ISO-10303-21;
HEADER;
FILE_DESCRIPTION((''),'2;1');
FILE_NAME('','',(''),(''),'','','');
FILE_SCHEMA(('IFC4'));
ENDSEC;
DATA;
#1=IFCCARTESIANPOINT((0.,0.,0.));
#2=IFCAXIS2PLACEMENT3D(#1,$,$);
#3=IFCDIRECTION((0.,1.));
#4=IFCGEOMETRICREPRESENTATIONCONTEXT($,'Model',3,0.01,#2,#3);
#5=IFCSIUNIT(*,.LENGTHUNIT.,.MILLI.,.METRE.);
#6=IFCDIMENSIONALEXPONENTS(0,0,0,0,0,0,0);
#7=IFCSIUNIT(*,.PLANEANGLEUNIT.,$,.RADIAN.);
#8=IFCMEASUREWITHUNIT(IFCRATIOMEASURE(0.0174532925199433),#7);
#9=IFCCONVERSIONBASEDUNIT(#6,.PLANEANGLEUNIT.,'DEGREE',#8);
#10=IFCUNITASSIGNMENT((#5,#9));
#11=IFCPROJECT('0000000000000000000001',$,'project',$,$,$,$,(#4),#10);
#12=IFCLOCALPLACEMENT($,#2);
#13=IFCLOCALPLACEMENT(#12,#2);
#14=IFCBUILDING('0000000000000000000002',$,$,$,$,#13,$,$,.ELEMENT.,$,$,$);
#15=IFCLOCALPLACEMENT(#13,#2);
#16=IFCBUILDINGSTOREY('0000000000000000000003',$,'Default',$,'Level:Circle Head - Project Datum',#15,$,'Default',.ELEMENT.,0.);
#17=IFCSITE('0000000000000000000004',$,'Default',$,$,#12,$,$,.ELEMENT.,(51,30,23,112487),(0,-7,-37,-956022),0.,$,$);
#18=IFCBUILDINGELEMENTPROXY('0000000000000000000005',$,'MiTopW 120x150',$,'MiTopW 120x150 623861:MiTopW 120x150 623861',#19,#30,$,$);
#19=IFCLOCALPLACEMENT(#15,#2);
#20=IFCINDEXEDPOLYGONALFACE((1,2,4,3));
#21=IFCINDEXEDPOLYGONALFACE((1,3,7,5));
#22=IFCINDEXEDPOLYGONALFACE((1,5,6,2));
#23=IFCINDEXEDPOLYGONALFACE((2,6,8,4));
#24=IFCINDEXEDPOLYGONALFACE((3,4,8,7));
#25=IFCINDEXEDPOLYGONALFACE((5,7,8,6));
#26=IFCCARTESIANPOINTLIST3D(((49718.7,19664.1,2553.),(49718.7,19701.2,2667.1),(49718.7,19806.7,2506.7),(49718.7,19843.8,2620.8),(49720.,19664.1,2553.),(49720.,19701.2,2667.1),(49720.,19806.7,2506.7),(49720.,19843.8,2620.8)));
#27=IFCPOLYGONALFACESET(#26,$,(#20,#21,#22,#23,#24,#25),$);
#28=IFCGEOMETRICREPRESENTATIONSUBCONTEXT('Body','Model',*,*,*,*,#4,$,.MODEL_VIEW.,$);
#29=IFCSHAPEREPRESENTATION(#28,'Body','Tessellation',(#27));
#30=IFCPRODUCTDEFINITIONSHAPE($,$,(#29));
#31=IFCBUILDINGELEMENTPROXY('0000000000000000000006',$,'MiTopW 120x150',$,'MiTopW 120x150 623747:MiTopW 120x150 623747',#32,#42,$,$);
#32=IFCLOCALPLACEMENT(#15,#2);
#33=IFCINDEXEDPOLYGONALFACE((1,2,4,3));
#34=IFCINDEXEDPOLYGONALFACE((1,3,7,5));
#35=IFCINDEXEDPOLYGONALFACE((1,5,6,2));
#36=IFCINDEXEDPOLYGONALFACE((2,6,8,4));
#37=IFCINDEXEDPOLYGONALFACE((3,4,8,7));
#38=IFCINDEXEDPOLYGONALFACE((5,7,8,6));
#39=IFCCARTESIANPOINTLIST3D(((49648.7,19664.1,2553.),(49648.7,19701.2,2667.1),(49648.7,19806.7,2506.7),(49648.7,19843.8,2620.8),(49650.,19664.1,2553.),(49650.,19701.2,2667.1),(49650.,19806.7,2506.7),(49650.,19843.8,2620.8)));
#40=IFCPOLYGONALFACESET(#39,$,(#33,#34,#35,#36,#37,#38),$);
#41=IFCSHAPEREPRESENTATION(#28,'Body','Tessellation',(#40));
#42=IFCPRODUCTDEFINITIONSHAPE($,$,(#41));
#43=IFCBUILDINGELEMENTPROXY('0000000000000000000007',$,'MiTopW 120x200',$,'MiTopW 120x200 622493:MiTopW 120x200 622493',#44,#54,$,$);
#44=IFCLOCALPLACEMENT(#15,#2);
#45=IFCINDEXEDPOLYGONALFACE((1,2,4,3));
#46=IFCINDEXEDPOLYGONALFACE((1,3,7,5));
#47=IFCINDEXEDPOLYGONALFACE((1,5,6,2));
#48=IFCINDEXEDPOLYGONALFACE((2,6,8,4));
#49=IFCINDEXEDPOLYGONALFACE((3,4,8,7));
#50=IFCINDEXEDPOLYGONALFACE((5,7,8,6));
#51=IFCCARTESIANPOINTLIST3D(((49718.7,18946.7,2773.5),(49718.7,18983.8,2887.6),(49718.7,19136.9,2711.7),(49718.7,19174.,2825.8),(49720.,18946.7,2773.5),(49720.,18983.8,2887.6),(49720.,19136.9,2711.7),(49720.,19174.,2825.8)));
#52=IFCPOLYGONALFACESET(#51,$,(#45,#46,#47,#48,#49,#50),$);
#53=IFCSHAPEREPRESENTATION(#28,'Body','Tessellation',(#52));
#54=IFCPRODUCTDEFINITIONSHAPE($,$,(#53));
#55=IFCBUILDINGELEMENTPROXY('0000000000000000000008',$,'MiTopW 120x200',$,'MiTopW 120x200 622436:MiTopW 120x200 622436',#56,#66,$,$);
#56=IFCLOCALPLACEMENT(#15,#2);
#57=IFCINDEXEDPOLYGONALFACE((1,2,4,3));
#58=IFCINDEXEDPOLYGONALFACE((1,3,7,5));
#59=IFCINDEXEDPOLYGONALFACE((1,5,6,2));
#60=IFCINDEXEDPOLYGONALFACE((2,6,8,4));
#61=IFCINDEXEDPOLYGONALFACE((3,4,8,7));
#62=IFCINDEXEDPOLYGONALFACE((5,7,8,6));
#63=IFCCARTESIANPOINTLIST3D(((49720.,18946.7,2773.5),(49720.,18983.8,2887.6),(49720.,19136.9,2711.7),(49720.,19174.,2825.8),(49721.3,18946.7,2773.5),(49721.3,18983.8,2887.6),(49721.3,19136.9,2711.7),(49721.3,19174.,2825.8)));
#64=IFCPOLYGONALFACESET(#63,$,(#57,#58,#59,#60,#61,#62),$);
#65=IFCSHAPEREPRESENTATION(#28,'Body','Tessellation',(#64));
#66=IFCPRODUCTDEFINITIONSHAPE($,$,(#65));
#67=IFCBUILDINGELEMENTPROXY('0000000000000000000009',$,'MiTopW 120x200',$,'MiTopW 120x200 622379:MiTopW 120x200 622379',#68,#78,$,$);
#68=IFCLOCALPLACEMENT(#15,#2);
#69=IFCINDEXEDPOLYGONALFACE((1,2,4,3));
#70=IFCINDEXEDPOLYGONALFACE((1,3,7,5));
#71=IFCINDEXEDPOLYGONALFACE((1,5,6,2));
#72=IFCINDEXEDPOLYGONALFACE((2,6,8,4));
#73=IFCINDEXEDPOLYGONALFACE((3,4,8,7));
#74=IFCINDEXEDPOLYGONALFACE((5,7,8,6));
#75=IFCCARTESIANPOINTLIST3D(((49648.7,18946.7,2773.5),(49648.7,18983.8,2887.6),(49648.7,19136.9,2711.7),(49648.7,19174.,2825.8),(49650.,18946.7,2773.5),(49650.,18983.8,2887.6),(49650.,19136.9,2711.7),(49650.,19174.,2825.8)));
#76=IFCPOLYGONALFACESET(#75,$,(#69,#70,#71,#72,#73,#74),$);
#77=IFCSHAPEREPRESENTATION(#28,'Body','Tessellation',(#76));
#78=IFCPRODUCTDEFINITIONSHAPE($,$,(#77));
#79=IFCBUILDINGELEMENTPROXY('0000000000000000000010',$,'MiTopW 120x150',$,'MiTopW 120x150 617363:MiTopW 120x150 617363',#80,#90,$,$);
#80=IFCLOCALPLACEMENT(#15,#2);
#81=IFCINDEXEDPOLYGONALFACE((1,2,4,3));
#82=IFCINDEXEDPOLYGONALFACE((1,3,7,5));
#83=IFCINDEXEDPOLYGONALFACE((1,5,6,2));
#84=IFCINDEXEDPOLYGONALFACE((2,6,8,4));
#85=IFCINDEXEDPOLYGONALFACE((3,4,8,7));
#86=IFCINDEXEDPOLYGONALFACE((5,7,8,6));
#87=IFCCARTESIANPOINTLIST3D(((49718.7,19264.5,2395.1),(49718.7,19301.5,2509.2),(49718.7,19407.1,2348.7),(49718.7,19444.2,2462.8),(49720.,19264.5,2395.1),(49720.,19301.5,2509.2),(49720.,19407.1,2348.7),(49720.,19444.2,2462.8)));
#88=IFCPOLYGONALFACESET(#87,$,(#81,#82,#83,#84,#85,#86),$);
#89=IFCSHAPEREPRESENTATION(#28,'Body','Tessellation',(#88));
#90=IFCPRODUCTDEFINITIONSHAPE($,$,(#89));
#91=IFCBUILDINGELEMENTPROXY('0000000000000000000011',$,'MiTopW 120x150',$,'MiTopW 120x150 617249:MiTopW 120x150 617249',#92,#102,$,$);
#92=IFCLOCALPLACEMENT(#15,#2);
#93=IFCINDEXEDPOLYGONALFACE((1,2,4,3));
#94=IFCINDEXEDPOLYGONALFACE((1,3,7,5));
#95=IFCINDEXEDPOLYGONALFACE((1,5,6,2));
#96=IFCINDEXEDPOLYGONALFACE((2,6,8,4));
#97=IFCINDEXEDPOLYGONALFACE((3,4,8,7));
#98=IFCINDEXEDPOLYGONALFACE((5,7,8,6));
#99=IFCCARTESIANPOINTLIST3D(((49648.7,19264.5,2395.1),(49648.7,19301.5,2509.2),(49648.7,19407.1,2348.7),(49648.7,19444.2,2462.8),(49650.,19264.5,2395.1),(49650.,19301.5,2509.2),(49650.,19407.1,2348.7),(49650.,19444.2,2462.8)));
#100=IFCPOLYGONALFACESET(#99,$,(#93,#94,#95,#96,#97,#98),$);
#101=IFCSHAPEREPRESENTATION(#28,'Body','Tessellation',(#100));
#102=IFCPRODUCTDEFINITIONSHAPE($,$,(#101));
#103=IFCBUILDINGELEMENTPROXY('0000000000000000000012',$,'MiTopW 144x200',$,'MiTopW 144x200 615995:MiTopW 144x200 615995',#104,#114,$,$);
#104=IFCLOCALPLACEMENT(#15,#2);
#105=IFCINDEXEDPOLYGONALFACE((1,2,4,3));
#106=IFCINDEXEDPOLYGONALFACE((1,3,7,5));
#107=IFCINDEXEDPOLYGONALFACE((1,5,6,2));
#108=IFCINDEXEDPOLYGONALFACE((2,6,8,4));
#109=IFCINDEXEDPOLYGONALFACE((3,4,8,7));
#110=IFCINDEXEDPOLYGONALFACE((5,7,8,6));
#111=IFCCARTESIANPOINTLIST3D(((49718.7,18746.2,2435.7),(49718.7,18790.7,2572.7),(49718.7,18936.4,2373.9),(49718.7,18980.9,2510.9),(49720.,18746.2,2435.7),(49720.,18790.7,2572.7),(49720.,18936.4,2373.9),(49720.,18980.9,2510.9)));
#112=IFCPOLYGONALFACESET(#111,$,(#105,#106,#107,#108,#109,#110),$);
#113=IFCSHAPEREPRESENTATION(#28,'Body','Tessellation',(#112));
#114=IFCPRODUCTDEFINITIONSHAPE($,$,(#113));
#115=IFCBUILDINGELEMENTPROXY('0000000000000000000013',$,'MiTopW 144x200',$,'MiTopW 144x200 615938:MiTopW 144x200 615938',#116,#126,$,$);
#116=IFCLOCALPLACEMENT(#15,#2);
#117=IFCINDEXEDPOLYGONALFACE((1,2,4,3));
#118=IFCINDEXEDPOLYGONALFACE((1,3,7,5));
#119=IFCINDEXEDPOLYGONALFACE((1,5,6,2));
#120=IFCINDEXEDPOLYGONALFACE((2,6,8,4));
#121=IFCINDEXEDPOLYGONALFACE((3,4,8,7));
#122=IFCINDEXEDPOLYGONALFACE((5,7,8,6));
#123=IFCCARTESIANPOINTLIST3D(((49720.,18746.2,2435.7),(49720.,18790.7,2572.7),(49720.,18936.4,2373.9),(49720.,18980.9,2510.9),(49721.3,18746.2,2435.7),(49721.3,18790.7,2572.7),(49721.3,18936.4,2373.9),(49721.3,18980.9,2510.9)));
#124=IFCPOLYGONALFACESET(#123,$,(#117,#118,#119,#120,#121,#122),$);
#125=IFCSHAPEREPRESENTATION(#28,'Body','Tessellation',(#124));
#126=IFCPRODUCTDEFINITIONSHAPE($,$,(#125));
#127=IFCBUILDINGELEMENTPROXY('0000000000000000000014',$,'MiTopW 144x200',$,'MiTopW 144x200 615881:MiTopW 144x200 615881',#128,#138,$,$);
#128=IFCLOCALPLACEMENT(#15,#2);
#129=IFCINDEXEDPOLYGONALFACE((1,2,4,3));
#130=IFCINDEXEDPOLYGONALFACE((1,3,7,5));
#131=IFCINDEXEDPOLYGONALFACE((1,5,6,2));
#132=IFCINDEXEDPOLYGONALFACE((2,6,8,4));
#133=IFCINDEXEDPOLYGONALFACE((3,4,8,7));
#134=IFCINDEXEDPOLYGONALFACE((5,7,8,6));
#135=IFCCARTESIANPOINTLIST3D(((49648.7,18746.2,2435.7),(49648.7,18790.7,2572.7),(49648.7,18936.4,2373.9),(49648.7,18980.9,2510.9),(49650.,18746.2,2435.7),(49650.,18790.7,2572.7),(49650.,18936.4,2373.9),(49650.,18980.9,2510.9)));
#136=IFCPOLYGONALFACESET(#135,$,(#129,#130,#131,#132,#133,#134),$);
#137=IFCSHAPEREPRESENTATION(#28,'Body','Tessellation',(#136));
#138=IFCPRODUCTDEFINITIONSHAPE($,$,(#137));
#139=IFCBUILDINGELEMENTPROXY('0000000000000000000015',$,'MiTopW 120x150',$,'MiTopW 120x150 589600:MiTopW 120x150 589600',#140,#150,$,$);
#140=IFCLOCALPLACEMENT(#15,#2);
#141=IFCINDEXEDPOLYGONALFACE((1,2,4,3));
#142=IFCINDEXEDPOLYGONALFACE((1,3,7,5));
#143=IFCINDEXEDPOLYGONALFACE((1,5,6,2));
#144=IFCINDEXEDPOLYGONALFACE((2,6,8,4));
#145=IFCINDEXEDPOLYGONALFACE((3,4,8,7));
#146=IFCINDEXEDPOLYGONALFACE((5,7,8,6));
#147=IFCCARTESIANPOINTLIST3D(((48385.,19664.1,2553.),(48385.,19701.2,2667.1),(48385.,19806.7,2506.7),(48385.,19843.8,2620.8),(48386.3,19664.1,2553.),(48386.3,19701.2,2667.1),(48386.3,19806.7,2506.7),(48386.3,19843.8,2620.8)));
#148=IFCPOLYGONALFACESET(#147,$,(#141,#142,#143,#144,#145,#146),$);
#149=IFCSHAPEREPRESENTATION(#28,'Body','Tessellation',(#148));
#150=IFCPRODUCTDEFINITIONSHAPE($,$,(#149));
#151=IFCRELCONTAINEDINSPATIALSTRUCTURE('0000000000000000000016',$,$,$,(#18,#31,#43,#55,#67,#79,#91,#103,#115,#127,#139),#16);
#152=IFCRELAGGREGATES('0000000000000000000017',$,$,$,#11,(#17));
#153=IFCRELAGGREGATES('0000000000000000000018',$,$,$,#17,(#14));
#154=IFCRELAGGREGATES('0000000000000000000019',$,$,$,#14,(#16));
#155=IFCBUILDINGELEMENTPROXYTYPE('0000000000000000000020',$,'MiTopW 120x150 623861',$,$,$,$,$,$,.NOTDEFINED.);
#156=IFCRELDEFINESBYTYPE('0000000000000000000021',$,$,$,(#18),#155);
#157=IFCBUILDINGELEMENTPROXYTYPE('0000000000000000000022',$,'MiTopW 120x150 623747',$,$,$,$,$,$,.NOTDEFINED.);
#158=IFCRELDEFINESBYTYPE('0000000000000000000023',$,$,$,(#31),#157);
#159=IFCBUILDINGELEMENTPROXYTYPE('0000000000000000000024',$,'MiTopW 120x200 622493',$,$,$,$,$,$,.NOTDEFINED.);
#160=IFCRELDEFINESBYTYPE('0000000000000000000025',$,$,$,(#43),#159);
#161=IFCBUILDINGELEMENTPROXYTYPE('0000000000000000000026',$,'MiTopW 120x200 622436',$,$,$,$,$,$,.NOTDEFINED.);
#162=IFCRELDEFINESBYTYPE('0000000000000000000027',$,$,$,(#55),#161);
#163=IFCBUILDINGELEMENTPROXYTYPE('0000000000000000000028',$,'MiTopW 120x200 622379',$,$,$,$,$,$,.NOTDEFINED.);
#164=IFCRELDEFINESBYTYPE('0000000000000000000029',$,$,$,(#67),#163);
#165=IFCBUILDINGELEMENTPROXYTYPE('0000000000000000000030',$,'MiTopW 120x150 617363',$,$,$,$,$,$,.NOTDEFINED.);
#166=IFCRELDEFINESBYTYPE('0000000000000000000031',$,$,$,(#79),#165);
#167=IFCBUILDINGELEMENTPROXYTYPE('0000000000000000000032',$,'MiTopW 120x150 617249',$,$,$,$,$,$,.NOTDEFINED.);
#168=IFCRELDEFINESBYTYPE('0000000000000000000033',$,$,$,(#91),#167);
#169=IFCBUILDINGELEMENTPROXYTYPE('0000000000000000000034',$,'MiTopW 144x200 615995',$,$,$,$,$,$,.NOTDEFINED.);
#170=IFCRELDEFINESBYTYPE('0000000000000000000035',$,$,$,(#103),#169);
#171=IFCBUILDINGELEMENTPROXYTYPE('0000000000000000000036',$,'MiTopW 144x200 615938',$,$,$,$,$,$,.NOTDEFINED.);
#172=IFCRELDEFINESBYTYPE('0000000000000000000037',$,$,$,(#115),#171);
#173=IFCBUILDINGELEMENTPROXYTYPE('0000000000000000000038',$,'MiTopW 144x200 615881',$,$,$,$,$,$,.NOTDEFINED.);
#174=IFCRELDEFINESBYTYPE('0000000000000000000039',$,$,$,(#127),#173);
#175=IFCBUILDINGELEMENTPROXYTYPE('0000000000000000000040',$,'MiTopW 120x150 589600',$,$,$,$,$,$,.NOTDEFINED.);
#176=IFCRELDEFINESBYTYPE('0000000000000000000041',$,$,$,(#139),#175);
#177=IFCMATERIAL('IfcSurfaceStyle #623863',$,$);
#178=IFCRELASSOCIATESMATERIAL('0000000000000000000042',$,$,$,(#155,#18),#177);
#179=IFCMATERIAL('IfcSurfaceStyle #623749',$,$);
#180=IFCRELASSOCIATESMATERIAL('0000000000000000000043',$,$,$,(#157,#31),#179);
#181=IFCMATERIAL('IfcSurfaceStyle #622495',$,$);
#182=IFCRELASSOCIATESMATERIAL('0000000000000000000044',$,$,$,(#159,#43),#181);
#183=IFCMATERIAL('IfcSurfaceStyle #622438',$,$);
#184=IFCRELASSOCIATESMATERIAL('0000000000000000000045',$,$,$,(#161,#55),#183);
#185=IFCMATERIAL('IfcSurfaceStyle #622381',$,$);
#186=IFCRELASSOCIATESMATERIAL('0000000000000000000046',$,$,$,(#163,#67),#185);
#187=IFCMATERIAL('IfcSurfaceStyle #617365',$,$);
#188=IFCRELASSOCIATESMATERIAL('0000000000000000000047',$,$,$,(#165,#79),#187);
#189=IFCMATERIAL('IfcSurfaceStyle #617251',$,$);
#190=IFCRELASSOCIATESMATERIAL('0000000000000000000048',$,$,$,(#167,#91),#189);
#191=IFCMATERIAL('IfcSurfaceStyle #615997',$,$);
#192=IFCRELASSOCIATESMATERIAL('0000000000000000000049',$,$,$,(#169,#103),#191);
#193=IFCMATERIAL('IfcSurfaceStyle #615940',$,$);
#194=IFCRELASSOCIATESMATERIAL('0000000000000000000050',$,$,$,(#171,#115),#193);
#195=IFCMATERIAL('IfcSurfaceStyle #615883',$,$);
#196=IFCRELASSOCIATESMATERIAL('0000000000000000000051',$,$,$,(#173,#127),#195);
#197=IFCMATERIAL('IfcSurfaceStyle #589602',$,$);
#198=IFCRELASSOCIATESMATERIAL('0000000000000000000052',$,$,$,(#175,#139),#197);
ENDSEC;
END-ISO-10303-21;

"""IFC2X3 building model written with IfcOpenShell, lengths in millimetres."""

from ifc_helpers import new_model, entity, si_unit, converted_unit, direction, frame, origin, place, context, subcontext, project, spatial, polyline, outline, extrude, source, transform, mapped, material, type_object, type_shapes, element, save


model = new_model("IFC2X3")

# Units and contexts
model_context = context("Model", 3, precision=0.01, world=origin(), true_north=direction((0.0, 1.0)))
body_context = subcontext(model_context, "Body", "Model", "MODEL_VIEW")
ifc_project = project(units=[si_unit("LENGTHUNIT", "METRE", prefix="MILLI"), converted_unit("PLANEANGLEUNIT", "DEGREE", entity("IfcRatioMeasure", 0.0174532925199433), si_unit("PLANEANGLEUNIT", "RADIAN"), dimensions=[0, 0, 0, 0, 0, 0, 0])], contexts=[model_context])

# Site, building, storey
site_placement = place(None, origin())
site = spatial("IfcSite", under=ifc_project, at=site_placement, Name="Default", CompositionType="ELEMENT", RefLatitude=(51, 30, 23, 112487), RefLongitude=(0, -7, -37, -956022), RefElevation=0.0)
building_placement = place(site_placement, origin())
building = spatial("IfcBuilding", under=site, at=building_placement, CompositionType="ELEMENT")
storey_placement = place(building_placement, origin())
storey = spatial("IfcBuildingStorey", under=building, at=storey_placement, Name="Default", ObjectType="Level:Circle Head - Project Datum", LongName="Default", CompositionType="ELEMENT", Elevation=0.0)

# Building element proxies
ifc_material_1 = material(Name="IfcSurfaceStyle #623863")
building_element_proxy_type_1 = type_object("IfcBuildingElementProxyType", Name="MiTopW 120x150 623861", PredefinedType="NOTDEFINED", material=ifc_material_1)
shared_shape_1 = source(origin(), body_context, "Body", "SweptSolid", [
    extrude(outline(polyline([(-75.0, -60.0), (75.0, -60.0), (75.0, 60.0), (-75.0, 60.0), (-75.0, -60.0)])), frame((75.0, 60.0, 0.0), z_axis=(0.0, 0.0, 1.0), x_axis=(-1.0, 0.0, 0.0)), (0.0, 0.0, 1.0), 1.3),
])
type_shapes(building_element_proxy_type_1, [shared_shape_1])
proxy_1_placement = place(building_placement, frame((49720.0, 19806.7, 2506.7), z_axis=(-1.0, 0.0, 0.0), x_axis=(0.0, -0.951057, 0.309017)))
element("IfcBuildingElementProxy", 1, at=proxy_1_placement, inside=storey, type_object=building_element_proxy_type_1, material=ifc_material_1, Name="MiTopW 120x150", ObjectType="MiTopW 120x150 623861:MiTopW 120x150 623861", context=body_context, shape_type="MappedRepresentation", body=[
    mapped(shared_shape_1, transform((0.0, 0.0, 0.0), scale=1.0)),
])
ifc_material_2 = material(Name="IfcSurfaceStyle #623749")
building_element_proxy_type_2 = type_object("IfcBuildingElementProxyType", Name="MiTopW 120x150 623747", PredefinedType="NOTDEFINED", material=ifc_material_2)
shared_shape_2 = source(origin(), body_context, "Body", "SweptSolid", [
    extrude(outline(polyline([(-75.0, -60.0), (75.0, -60.0), (75.0, 60.0), (-75.0, 60.0), (-75.0, -60.0)])), frame((75.0, 60.0, 0.0), z_axis=(0.0, 0.0, 1.0), x_axis=(-1.0, 0.0, 0.0)), (0.0, 0.0, 1.0), 1.3),
])
type_shapes(building_element_proxy_type_2, [shared_shape_2])
proxy_2_placement = place(building_placement, frame((49650.0, 19806.7, 2506.7), z_axis=(-1.0, 0.0, 0.0), x_axis=(0.0, -0.951057, 0.309017)))
element("IfcBuildingElementProxy", 2, at=proxy_2_placement, inside=storey, type_object=building_element_proxy_type_2, material=ifc_material_2, Name="MiTopW 120x150", ObjectType="MiTopW 120x150 623747:MiTopW 120x150 623747", context=body_context, shape_type="MappedRepresentation", body=[
    mapped(shared_shape_2, transform((0.0, 0.0, 0.0), scale=1.0)),
])
ifc_material_3 = material(Name="IfcSurfaceStyle #622495")
building_element_proxy_type_3 = type_object("IfcBuildingElementProxyType", Name="MiTopW 120x200 622493", PredefinedType="NOTDEFINED", material=ifc_material_3)
shared_shape_3 = source(origin(), body_context, "Body", "SweptSolid", [
    extrude(outline(polyline([(-100.0, -60.0), (100.0, -60.0), (100.0, 60.0), (-100.0, 60.0), (-100.0, -60.0)])), frame((100.0, 60.0, 0.0), z_axis=(0.0, 0.0, 1.0), x_axis=(-1.0, 0.0, 0.0)), (0.0, 0.0, 1.0), 1.3),
])
type_shapes(building_element_proxy_type_3, [shared_shape_3])
proxy_3_placement = place(building_placement, frame((49720.0, 19136.9, 2711.7), z_axis=(-1.0, 0.0, 0.0), x_axis=(0.0, -0.951057, 0.309017)))
element("IfcBuildingElementProxy", 3, at=proxy_3_placement, inside=storey, type_object=building_element_proxy_type_3, material=ifc_material_3, Name="MiTopW 120x200", ObjectType="MiTopW 120x200 622493:MiTopW 120x200 622493", context=body_context, shape_type="MappedRepresentation", body=[
    mapped(shared_shape_3, transform((0.0, 0.0, 0.0), scale=1.0)),
])
ifc_material_4 = material(Name="IfcSurfaceStyle #622438")
building_element_proxy_type_4 = type_object("IfcBuildingElementProxyType", Name="MiTopW 120x200 622436", PredefinedType="NOTDEFINED", material=ifc_material_4)
shared_shape_4 = source(origin(), body_context, "Body", "SweptSolid", [
    extrude(outline(polyline([(-100.0, -60.0), (100.0, -60.0), (100.0, 60.0), (-100.0, 60.0), (-100.0, -60.0)])), frame((100.0, 60.0, 0.0), z_axis=(0.0, 0.0, 1.0), x_axis=(-1.0, 0.0, 0.0)), (0.0, 0.0, 1.0), 1.3),
])
type_shapes(building_element_proxy_type_4, [shared_shape_4])
proxy_4_placement = place(building_placement, frame((49721.3, 19136.9, 2711.7), z_axis=(-1.0, 0.0, 0.0), x_axis=(0.0, -0.951057, 0.309017)))
element("IfcBuildingElementProxy", 4, at=proxy_4_placement, inside=storey, type_object=building_element_proxy_type_4, material=ifc_material_4, Name="MiTopW 120x200", ObjectType="MiTopW 120x200 622436:MiTopW 120x200 622436", context=body_context, shape_type="MappedRepresentation", body=[
    mapped(shared_shape_4, transform((0.0, 0.0, 0.0), scale=1.0)),
])
ifc_material_5 = material(Name="IfcSurfaceStyle #622381")
building_element_proxy_type_5 = type_object("IfcBuildingElementProxyType", Name="MiTopW 120x200 622379", PredefinedType="NOTDEFINED", material=ifc_material_5)
shared_shape_5 = source(origin(), body_context, "Body", "SweptSolid", [
    extrude(outline(polyline([(-100.0, -60.0), (100.0, -60.0), (100.0, 60.0), (-100.0, 60.0), (-100.0, -60.0)])), frame((100.0, 60.0, 0.0), z_axis=(0.0, 0.0, 1.0), x_axis=(-1.0, 0.0, 0.0)), (0.0, 0.0, 1.0), 1.3),
])
type_shapes(building_element_proxy_type_5, [shared_shape_5])
proxy_5_placement = place(building_placement, frame((49650.0, 19136.9, 2711.7), z_axis=(-1.0, 0.0, 0.0), x_axis=(0.0, -0.951057, 0.309017)))
element("IfcBuildingElementProxy", 5, at=proxy_5_placement, inside=storey, type_object=building_element_proxy_type_5, material=ifc_material_5, Name="MiTopW 120x200", ObjectType="MiTopW 120x200 622379:MiTopW 120x200 622379", context=body_context, shape_type="MappedRepresentation", body=[
    mapped(shared_shape_5, transform((0.0, 0.0, 0.0), scale=1.0)),
])
ifc_material_6 = material(Name="IfcSurfaceStyle #617365")
building_element_proxy_type_6 = type_object("IfcBuildingElementProxyType", Name="MiTopW 120x150 617363", PredefinedType="NOTDEFINED", material=ifc_material_6)
shared_shape_6 = source(origin(), body_context, "Body", "SweptSolid", [
    extrude(outline(polyline([(-75.0, -60.0), (75.0, -60.0), (75.0, 60.0), (-75.0, 60.0), (-75.0, -60.0)])), frame((75.0, 60.0, 0.0), z_axis=(0.0, 0.0, 1.0), x_axis=(-1.0, 0.0, 0.0)), (0.0, 0.0, 1.0), 1.3),
])
type_shapes(building_element_proxy_type_6, [shared_shape_6])
proxy_6_placement = place(building_placement, frame((49720.0, 19407.1, 2348.7), z_axis=(-1.0, 0.0, 0.0), x_axis=(0.0, -0.951057, 0.309017)))
element("IfcBuildingElementProxy", 6, at=proxy_6_placement, inside=storey, type_object=building_element_proxy_type_6, material=ifc_material_6, Name="MiTopW 120x150", ObjectType="MiTopW 120x150 617363:MiTopW 120x150 617363", context=body_context, shape_type="MappedRepresentation", body=[
    mapped(shared_shape_6, transform((0.0, 0.0, 0.0), scale=1.0)),
])
ifc_material_7 = material(Name="IfcSurfaceStyle #617251")
building_element_proxy_type_7 = type_object("IfcBuildingElementProxyType", Name="MiTopW 120x150 617249", PredefinedType="NOTDEFINED", material=ifc_material_7)
shared_shape_7 = source(origin(), body_context, "Body", "SweptSolid", [
    extrude(outline(polyline([(-75.0, -60.0), (75.0, -60.0), (75.0, 60.0), (-75.0, 60.0), (-75.0, -60.0)])), frame((75.0, 60.0, 0.0), z_axis=(0.0, 0.0, 1.0), x_axis=(-1.0, 0.0, 0.0)), (0.0, 0.0, 1.0), 1.3),
])
type_shapes(building_element_proxy_type_7, [shared_shape_7])
proxy_7_placement = place(building_placement, frame((49650.0, 19407.1, 2348.7), z_axis=(-1.0, 0.0, 0.0), x_axis=(0.0, -0.951057, 0.309017)))
element("IfcBuildingElementProxy", 7, at=proxy_7_placement, inside=storey, type_object=building_element_proxy_type_7, material=ifc_material_7, Name="MiTopW 120x150", ObjectType="MiTopW 120x150 617249:MiTopW 120x150 617249", context=body_context, shape_type="MappedRepresentation", body=[
    mapped(shared_shape_7, transform((0.0, 0.0, 0.0), scale=1.0)),
])
ifc_material_8 = material(Name="IfcSurfaceStyle #615997")
building_element_proxy_type_8 = type_object("IfcBuildingElementProxyType", Name="MiTopW 144x200 615995", PredefinedType="NOTDEFINED", material=ifc_material_8)
shared_shape_8 = source(origin(), body_context, "Body", "SweptSolid", [
    extrude(outline(polyline([(-100.0, -72.0), (100.0, -72.0), (100.0, 72.0), (-100.0, 72.0), (-100.0, -72.0)])), frame((100.0, 72.0, 0.0), z_axis=(0.0, 0.0, 1.0), x_axis=(-1.0, 0.0, 0.0)), (0.0, 0.0, 1.0), 1.3),
])
type_shapes(building_element_proxy_type_8, [shared_shape_8])
proxy_8_placement = place(building_placement, frame((49720.0, 18936.4, 2373.9), z_axis=(-1.0, 0.0, 0.0), x_axis=(0.0, -0.951057, 0.309017)))
element("IfcBuildingElementProxy", 8, at=proxy_8_placement, inside=storey, type_object=building_element_proxy_type_8, material=ifc_material_8, Name="MiTopW 144x200", ObjectType="MiTopW 144x200 615995:MiTopW 144x200 615995", context=body_context, shape_type="MappedRepresentation", body=[
    mapped(shared_shape_8, transform((0.0, 0.0, 0.0), scale=1.0)),
])
ifc_material_9 = material(Name="IfcSurfaceStyle #615940")
building_element_proxy_type_9 = type_object("IfcBuildingElementProxyType", Name="MiTopW 144x200 615938", PredefinedType="NOTDEFINED", material=ifc_material_9)
shared_shape_9 = source(origin(), body_context, "Body", "SweptSolid", [
    extrude(outline(polyline([(-100.0, -72.0), (100.0, -72.0), (100.0, 72.0), (-100.0, 72.0), (-100.0, -72.0)])), frame((100.0, 72.0, 0.0), z_axis=(0.0, 0.0, 1.0), x_axis=(-1.0, 0.0, 0.0)), (0.0, 0.0, 1.0), 1.3),
])
type_shapes(building_element_proxy_type_9, [shared_shape_9])
proxy_9_placement = place(building_placement, frame((49721.3, 18936.4, 2373.9), z_axis=(-1.0, 0.0, 0.0), x_axis=(0.0, -0.951057, 0.309017)))
element("IfcBuildingElementProxy", 9, at=proxy_9_placement, inside=storey, type_object=building_element_proxy_type_9, material=ifc_material_9, Name="MiTopW 144x200", ObjectType="MiTopW 144x200 615938:MiTopW 144x200 615938", context=body_context, shape_type="MappedRepresentation", body=[
    mapped(shared_shape_9, transform((0.0, 0.0, 0.0), scale=1.0)),
])
ifc_material_10 = material(Name="IfcSurfaceStyle #615883")
building_element_proxy_type_10 = type_object("IfcBuildingElementProxyType", Name="MiTopW 144x200 615881", PredefinedType="NOTDEFINED", material=ifc_material_10)
shared_shape_10 = source(origin(), body_context, "Body", "SweptSolid", [
    extrude(outline(polyline([(-100.0, -72.0), (100.0, -72.0), (100.0, 72.0), (-100.0, 72.0), (-100.0, -72.0)])), frame((100.0, 72.0, 0.0), z_axis=(0.0, 0.0, 1.0), x_axis=(-1.0, 0.0, 0.0)), (0.0, 0.0, 1.0), 1.3),
])
type_shapes(building_element_proxy_type_10, [shared_shape_10])
proxy_10_placement = place(building_placement, frame((49650.0, 18936.4, 2373.9), z_axis=(-1.0, 0.0, 0.0), x_axis=(0.0, -0.951057, 0.309017)))
element("IfcBuildingElementProxy", 10, at=proxy_10_placement, inside=storey, type_object=building_element_proxy_type_10, material=ifc_material_10, Name="MiTopW 144x200", ObjectType="MiTopW 144x200 615881:MiTopW 144x200 615881", context=body_context, shape_type="MappedRepresentation", body=[
    mapped(shared_shape_10, transform((0.0, 0.0, 0.0), scale=1.0)),
])
ifc_material_11 = material(Name="IfcSurfaceStyle #589602")
building_element_proxy_type_11 = type_object("IfcBuildingElementProxyType", Name="MiTopW 120x150 589600", PredefinedType="NOTDEFINED", material=ifc_material_11)
shared_shape_11 = source(origin(), body_context, "Body", "SweptSolid", [
    extrude(outline(polyline([(-75.0, -60.0), (75.0, -60.0), (75.0, 60.0), (-75.0, 60.0), (-75.0, -60.0)])), frame((75.0, 60.0, 0.0), z_axis=(0.0, 0.0, 1.0), x_axis=(-1.0, 0.0, 0.0)), (0.0, 0.0, 1.0), 1.3),
])
type_shapes(building_element_proxy_type_11, [shared_shape_11])
proxy_11_placement = place(building_placement, frame((48386.3, 19806.7, 2506.7), z_axis=(-1.0, 0.0, 0.0), x_axis=(0.0, -0.951057, 0.309017)))
element("IfcBuildingElementProxy", 11, at=proxy_11_placement, inside=storey, type_object=building_element_proxy_type_11, material=ifc_material_11, Name="MiTopW 120x150", ObjectType="MiTopW 120x150 589600:MiTopW 120x150 589600", context=body_context, shape_type="MappedRepresentation", body=[
    mapped(shared_shape_11, transform((0.0, 0.0, 0.0), scale=1.0)),
])

save(model, "model.ifc")
